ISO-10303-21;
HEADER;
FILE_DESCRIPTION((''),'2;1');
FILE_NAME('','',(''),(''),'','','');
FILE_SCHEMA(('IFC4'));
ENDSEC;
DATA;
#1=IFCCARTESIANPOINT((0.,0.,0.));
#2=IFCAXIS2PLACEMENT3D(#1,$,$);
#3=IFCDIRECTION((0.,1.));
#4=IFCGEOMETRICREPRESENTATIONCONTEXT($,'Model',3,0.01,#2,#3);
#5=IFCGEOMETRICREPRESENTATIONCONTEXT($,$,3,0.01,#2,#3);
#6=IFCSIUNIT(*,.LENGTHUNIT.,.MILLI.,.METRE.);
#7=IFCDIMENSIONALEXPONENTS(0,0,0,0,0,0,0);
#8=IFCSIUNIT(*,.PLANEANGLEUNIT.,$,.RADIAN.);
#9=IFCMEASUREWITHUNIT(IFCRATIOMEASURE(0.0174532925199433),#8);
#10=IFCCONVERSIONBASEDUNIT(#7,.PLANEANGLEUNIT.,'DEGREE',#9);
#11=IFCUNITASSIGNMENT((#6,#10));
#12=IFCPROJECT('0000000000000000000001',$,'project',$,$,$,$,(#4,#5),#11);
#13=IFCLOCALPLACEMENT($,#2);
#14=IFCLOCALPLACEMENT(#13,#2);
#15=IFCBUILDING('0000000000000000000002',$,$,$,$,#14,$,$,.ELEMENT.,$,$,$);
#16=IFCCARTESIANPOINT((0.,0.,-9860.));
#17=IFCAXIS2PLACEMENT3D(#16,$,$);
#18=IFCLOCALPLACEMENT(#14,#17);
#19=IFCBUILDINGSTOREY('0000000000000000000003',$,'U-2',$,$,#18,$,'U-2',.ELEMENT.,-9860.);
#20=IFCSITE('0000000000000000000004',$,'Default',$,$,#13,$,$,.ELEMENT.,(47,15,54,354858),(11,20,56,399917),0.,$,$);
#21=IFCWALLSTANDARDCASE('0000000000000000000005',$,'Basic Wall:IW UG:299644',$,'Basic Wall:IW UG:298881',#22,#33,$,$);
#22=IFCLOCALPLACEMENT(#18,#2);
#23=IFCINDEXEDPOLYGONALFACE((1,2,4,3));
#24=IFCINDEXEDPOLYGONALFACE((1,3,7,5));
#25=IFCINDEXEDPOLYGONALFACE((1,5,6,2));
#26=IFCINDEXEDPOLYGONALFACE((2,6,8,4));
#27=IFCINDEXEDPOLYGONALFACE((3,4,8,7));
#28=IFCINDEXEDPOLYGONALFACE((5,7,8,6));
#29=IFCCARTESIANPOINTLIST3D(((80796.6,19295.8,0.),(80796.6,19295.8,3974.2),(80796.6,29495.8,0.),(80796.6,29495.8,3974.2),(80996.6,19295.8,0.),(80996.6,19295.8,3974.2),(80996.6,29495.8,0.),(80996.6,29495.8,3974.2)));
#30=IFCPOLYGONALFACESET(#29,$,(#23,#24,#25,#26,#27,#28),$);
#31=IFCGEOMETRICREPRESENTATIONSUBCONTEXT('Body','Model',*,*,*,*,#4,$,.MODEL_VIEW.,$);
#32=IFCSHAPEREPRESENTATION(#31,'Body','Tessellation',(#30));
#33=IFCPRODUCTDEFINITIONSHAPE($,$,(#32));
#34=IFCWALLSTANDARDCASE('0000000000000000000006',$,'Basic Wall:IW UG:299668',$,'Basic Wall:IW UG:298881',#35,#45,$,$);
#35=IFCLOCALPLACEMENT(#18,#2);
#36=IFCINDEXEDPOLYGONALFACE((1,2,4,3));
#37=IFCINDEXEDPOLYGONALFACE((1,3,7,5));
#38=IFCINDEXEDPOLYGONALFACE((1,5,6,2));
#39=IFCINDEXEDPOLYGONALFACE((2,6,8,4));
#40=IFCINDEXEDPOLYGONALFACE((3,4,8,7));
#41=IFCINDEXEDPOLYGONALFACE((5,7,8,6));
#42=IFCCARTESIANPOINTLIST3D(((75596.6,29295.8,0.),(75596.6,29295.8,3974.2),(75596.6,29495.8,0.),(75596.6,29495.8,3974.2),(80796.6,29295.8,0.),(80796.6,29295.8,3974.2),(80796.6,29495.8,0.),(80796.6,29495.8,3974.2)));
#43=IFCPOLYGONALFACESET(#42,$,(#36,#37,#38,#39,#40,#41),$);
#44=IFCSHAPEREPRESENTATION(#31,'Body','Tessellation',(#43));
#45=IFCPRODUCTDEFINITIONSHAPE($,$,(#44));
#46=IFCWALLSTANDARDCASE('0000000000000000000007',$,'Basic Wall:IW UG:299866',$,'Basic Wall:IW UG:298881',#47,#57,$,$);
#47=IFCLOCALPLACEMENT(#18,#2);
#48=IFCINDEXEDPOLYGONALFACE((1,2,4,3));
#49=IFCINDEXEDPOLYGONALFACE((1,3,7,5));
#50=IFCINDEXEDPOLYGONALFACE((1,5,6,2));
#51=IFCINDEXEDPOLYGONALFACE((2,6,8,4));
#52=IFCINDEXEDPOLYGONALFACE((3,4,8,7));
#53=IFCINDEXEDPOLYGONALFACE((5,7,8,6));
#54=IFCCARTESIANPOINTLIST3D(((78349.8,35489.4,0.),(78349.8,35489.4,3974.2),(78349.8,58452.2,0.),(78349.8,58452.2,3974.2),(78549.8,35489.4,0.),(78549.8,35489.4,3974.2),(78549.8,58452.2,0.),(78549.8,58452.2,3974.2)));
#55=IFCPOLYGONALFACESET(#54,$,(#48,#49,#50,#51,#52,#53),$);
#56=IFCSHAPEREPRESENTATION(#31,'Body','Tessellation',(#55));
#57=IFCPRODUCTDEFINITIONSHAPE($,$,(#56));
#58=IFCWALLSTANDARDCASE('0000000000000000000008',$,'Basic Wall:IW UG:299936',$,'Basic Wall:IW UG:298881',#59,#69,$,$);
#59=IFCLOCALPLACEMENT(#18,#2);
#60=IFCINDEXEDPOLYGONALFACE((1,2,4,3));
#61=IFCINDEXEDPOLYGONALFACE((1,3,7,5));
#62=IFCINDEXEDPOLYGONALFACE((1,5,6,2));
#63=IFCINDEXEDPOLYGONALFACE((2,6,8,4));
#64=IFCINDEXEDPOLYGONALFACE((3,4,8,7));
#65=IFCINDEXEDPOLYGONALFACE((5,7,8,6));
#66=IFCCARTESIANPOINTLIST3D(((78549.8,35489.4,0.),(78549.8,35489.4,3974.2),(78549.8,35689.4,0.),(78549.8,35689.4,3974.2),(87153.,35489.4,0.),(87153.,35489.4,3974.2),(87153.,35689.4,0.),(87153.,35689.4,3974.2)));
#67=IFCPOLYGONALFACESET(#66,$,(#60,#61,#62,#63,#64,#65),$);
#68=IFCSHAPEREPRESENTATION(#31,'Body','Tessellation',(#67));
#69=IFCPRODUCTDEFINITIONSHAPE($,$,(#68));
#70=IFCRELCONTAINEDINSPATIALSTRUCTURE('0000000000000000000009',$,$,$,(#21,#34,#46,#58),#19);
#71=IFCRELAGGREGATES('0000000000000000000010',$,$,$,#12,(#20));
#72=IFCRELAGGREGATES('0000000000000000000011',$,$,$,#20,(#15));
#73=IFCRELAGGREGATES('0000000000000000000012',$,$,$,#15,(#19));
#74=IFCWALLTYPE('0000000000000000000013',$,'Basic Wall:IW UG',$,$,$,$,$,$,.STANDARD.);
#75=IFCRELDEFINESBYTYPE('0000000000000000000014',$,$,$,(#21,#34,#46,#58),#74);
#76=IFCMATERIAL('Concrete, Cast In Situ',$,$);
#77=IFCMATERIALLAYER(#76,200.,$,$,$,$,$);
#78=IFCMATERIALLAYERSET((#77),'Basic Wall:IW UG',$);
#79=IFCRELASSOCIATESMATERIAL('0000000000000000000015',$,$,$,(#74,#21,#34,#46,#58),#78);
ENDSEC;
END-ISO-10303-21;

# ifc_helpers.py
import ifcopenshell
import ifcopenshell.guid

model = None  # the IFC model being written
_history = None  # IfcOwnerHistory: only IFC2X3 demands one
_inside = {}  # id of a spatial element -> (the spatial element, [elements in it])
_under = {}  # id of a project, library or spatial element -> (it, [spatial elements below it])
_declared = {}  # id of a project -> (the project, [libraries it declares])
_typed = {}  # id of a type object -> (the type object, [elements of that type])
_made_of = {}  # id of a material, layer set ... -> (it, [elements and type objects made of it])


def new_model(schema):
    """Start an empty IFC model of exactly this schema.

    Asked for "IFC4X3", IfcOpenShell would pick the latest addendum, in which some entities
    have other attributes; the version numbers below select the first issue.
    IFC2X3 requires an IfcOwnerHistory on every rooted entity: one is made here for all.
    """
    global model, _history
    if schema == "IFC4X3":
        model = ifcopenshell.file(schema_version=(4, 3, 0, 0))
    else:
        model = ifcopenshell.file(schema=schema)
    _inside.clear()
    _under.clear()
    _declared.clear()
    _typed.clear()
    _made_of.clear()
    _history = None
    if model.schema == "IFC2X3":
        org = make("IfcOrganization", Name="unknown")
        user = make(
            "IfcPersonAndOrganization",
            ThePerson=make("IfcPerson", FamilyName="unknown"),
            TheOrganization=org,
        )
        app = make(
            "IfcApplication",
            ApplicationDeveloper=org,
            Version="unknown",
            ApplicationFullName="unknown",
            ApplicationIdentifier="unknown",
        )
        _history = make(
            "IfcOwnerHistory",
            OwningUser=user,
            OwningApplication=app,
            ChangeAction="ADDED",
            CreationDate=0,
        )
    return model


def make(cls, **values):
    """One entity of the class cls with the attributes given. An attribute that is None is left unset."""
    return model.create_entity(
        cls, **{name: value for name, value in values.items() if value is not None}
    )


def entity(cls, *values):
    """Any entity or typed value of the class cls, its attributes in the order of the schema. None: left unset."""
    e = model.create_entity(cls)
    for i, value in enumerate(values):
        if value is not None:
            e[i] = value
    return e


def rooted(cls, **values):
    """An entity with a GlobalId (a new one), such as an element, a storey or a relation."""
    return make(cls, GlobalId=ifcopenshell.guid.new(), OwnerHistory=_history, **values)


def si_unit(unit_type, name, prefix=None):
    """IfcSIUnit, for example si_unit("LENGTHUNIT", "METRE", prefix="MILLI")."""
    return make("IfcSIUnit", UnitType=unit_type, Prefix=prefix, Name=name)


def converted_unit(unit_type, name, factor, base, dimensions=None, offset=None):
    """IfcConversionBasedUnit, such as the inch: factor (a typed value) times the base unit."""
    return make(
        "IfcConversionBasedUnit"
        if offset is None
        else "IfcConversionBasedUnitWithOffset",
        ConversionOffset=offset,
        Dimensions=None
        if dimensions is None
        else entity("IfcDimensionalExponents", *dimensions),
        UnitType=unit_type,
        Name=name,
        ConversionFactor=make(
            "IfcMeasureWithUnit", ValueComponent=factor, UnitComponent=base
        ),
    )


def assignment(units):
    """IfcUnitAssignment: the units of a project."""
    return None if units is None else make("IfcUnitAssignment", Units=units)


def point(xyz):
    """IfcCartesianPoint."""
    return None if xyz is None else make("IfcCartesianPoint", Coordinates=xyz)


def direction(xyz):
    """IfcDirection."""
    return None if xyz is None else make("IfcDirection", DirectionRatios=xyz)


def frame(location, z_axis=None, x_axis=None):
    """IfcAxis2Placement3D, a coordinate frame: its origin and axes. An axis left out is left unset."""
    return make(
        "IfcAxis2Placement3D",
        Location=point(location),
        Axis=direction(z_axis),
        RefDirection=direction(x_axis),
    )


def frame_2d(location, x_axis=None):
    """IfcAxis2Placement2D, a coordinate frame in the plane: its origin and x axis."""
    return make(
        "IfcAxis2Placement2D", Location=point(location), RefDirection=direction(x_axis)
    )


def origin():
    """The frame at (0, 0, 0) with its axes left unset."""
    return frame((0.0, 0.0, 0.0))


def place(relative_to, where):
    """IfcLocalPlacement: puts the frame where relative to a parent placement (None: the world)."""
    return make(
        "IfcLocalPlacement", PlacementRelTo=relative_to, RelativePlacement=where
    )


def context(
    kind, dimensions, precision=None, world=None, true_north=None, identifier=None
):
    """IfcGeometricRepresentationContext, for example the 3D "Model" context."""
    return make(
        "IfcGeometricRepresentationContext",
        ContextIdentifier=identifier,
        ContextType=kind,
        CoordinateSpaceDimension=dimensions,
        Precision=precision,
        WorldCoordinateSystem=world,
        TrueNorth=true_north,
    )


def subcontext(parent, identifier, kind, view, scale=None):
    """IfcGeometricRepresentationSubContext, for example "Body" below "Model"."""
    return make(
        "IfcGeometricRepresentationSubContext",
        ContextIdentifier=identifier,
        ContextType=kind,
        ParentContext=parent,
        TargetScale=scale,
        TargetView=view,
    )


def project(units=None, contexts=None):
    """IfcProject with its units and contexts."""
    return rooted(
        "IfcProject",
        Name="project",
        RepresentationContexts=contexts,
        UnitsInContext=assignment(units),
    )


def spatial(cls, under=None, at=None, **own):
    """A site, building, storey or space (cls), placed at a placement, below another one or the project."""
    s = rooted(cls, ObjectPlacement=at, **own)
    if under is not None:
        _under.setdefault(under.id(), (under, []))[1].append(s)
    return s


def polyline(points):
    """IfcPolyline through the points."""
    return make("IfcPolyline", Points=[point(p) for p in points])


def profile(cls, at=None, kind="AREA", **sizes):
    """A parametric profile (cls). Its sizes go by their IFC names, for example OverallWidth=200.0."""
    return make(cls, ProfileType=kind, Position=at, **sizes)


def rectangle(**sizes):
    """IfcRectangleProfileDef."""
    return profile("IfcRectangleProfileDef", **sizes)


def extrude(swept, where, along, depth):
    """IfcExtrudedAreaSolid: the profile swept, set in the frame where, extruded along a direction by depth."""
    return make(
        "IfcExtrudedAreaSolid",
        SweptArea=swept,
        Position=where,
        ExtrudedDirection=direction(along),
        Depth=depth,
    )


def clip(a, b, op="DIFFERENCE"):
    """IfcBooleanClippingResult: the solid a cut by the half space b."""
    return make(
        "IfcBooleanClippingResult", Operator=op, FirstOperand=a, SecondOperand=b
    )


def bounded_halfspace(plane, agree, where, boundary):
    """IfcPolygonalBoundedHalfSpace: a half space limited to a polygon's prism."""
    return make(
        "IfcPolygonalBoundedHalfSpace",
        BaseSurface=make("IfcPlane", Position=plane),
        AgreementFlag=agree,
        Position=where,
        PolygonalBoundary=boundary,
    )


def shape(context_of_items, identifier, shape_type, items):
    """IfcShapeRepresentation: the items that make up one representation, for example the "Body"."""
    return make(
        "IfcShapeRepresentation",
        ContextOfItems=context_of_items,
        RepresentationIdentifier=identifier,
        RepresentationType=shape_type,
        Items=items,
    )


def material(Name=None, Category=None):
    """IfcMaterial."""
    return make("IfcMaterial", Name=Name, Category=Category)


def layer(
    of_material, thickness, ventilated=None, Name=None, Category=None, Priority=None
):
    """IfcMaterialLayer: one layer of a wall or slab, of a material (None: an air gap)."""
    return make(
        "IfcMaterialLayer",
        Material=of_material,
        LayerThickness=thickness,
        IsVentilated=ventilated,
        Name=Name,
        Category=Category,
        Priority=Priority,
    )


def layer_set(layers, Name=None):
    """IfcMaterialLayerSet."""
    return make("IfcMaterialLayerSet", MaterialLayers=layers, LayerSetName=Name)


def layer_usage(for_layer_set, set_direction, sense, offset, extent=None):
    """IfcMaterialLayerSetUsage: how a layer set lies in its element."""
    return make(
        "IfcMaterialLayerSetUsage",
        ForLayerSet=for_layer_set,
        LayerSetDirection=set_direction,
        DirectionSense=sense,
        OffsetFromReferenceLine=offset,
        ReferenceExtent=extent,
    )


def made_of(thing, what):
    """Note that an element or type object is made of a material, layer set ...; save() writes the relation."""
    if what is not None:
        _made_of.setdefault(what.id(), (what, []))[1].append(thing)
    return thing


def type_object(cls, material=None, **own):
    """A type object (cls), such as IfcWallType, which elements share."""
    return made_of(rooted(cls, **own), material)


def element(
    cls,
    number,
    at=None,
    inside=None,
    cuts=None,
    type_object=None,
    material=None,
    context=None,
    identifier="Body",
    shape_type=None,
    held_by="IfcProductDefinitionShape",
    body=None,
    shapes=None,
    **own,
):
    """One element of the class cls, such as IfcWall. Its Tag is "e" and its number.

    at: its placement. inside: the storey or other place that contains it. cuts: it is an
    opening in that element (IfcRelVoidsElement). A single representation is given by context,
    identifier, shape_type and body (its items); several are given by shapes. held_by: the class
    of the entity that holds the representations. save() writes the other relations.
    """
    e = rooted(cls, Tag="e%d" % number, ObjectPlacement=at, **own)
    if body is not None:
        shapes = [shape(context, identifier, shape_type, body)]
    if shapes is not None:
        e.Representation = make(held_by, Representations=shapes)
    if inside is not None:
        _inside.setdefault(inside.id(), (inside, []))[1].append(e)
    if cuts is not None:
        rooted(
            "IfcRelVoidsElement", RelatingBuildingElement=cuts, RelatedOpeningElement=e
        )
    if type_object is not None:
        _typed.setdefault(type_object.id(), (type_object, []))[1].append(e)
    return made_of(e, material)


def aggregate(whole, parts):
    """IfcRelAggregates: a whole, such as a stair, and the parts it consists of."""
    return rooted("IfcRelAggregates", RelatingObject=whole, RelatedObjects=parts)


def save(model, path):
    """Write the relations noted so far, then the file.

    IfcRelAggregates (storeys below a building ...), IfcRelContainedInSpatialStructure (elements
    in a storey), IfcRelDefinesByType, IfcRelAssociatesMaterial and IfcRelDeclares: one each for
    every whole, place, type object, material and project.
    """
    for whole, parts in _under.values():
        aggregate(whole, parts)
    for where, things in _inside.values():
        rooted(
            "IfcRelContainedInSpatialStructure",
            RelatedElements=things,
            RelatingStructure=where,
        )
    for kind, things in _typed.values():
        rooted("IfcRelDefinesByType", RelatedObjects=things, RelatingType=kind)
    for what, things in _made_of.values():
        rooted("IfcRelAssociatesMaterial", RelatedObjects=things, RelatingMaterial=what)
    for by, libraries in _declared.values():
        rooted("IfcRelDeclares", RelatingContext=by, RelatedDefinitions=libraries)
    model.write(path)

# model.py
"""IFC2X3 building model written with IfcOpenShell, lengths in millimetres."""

from ifc_helpers import new_model, entity, si_unit, converted_unit, direction, frame, frame_2d, origin, place, context, subcontext, project, spatial, polyline, rectangle, extrude, clip, bounded_halfspace, material, layer, layer_set, layer_usage, type_object, element, save


model = new_model("IFC2X3")

# Units and contexts
model_context = context("Model", 3, precision=0.01, world=origin(), true_north=direction((0.0, 1.0)))
context_of_model = context(None, 3, precision=0.01, world=origin(), true_north=direction((0.0, 1.0)))
body_context = subcontext(model_context, "Body", "Model", "MODEL_VIEW")
ifc_project = project(units=[si_unit("LENGTHUNIT", "METRE", prefix="MILLI"), converted_unit("PLANEANGLEUNIT", "DEGREE", entity("IfcRatioMeasure", 0.0174532925199433), si_unit("PLANEANGLEUNIT", "RADIAN"), dimensions=[0, 0, 0, 0, 0, 0, 0])], contexts=[model_context, context_of_model])

# Site, building, storey
site_placement = place(None, origin())
site = spatial("IfcSite", under=ifc_project, at=site_placement, Name="Default", CompositionType="ELEMENT", RefLatitude=(47, 15, 54, 354858), RefLongitude=(11, 20, 56, 399917), RefElevation=0.0)
building_placement = place(site_placement, origin())
building = spatial("IfcBuilding", under=site, at=building_placement, CompositionType="ELEMENT")
storey_placement = place(building_placement, frame((0.0, 0.0, -9860.0)))
storey = spatial("IfcBuildingStorey", under=building, at=storey_placement, Name="U-2", LongName="U-2", CompositionType="ELEMENT", Elevation=-9860.0)

# Walls
ifc_material_1 = material(Name="Concrete, Cast In Situ")
ifc_layer_1 = layer(ifc_material_1, 200.0)
ifc_layer_set_1 = layer_set([ifc_layer_1], Name="Basic Wall:IW UG")
wall_type_1 = type_object("IfcWallType", Name="Basic Wall:IW UG", PredefinedType="STANDARD", material=ifc_layer_set_1)
ifc_layer_usage_1 = layer_usage(ifc_layer_set_1, "AXIS2", "NEGATIVE", 100.0)
wall_1_placement = place(storey_placement, frame((80896.6, 19295.8, 0.0), z_axis=(0.0, 0.0, 1.0), x_axis=(0.0, 1.0, 0.0)))
element("IfcWallStandardCase", 1, at=wall_1_placement, inside=storey, type_object=wall_type_1, material=ifc_layer_usage_1, Name="Basic Wall:IW UG:299644", ObjectType="Basic Wall:IW UG:298881", context=body_context, shape_type="Clipping", body=[
    clip(extrude(rectangle(XDim=10200.0, YDim=200.0, at=frame_2d((5100.0, 0.0), x_axis=(-1.0, 0.0))), origin(), (0.0, 0.0, 1.0), 3974.2), bounded_halfspace(frame((0.0, -100.0, 3974.2), z_axis=(0.0, 0.0, -1.0), x_axis=(1.0, 0.0, 0.0)), True, frame((0.0, -100.0, 3974.2)), polyline([(0.0, 0.0), (10200.0, 0.0), (10200.0, 200.0), (10000.0, 200.0), (0.0, 200.0), (0.0, 0.0)]))),
])
ifc_layer_usage_2 = layer_usage(ifc_layer_set_1, "AXIS2", "NEGATIVE", 100.0)
wall_2_placement = place(storey_placement, frame((80796.6, 29395.8, 0.0), z_axis=(0.0, 0.0, 1.0), x_axis=(-1.0, 0.0, 0.0)))
element("IfcWallStandardCase", 2, at=wall_2_placement, inside=storey, type_object=wall_type_1, material=ifc_layer_usage_2, Name="Basic Wall:IW UG:299668", ObjectType="Basic Wall:IW UG:298881", context=body_context, shape_type="Clipping", body=[
    clip(extrude(rectangle(XDim=5200.0, YDim=200.0, at=frame_2d((2600.0, 0.0), x_axis=(-1.0, 0.0))), origin(), (0.0, 0.0, 1.0), 3974.2), bounded_halfspace(frame((0.0, -100.0, 3974.2), z_axis=(0.0, 0.0, -1.0), x_axis=(0.0, -1.0, 0.0)), True, frame((0.0, -100.0, 3974.2)), polyline([(0.0, 0.0), (5200.0, 0.0), (5200.0, 200.0), (0.0, 200.0), (0.0, 0.0)]))),
])
ifc_layer_usage_3 = layer_usage(ifc_layer_set_1, "AXIS2", "NEGATIVE", 100.0)
wall_3_placement = place(storey_placement, frame((78449.8, 58452.2, 0.0), z_axis=(0.0, 0.0, 1.0), x_axis=(0.0, -1.0, 0.0)))
element("IfcWallStandardCase", 3, at=wall_3_placement, inside=storey, type_object=wall_type_1, material=ifc_layer_usage_3, Name="Basic Wall:IW UG:299866", ObjectType="Basic Wall:IW UG:298881", context=body_context, shape_type="Clipping", body=[
    clip(extrude(rectangle(XDim=22962.8, YDim=200.0, at=frame_2d((11481.4, 0.0), x_axis=(-1.0, 0.0))), origin(), (0.0, 0.0, 1.0), 3974.2), bounded_halfspace(frame((0.0, -100.0, 3974.2), z_axis=(0.0, 0.0, -1.0), x_axis=(-1.0, 0.0, 0.0)), True, frame((0.0, -100.0, 3974.2)), polyline([(0.0, 0.0), (22962.8, 0.0), (22962.8, 200.0), (22762.8, 200.0), (0.0, 200.0), (0.0, 0.0)]))),
])
ifc_layer_usage_4 = layer_usage(ifc_layer_set_1, "AXIS2", "NEGATIVE", 100.0)
wall_4_placement = place(storey_placement, frame((78549.8, 35589.4, 0.0)))
element("IfcWallStandardCase", 4, at=wall_4_placement, inside=storey, type_object=wall_type_1, material=ifc_layer_usage_4, Name="Basic Wall:IW UG:299936", ObjectType="Basic Wall:IW UG:298881", context=body_context, shape_type="Clipping", body=[
    clip(extrude(rectangle(XDim=8603.2, YDim=200.0, at=frame_2d((4301.6, 0.0), x_axis=(-1.0, 0.0))), origin(), (0.0, 0.0, 1.0), 3974.2), bounded_halfspace(frame((0.0, -100.0, 3974.2), z_axis=(0.0, 0.0, -1.0), x_axis=(0.0, 1.0, 0.0)), True, frame((0.0, -100.0, 3974.2)), polyline([(0.0, 0.0), (8603.2, 0.0), (8603.2, 200.0), (0.0, 200.0), (0.0, 0.0)]))),
])

save(model, "model.ifc")
